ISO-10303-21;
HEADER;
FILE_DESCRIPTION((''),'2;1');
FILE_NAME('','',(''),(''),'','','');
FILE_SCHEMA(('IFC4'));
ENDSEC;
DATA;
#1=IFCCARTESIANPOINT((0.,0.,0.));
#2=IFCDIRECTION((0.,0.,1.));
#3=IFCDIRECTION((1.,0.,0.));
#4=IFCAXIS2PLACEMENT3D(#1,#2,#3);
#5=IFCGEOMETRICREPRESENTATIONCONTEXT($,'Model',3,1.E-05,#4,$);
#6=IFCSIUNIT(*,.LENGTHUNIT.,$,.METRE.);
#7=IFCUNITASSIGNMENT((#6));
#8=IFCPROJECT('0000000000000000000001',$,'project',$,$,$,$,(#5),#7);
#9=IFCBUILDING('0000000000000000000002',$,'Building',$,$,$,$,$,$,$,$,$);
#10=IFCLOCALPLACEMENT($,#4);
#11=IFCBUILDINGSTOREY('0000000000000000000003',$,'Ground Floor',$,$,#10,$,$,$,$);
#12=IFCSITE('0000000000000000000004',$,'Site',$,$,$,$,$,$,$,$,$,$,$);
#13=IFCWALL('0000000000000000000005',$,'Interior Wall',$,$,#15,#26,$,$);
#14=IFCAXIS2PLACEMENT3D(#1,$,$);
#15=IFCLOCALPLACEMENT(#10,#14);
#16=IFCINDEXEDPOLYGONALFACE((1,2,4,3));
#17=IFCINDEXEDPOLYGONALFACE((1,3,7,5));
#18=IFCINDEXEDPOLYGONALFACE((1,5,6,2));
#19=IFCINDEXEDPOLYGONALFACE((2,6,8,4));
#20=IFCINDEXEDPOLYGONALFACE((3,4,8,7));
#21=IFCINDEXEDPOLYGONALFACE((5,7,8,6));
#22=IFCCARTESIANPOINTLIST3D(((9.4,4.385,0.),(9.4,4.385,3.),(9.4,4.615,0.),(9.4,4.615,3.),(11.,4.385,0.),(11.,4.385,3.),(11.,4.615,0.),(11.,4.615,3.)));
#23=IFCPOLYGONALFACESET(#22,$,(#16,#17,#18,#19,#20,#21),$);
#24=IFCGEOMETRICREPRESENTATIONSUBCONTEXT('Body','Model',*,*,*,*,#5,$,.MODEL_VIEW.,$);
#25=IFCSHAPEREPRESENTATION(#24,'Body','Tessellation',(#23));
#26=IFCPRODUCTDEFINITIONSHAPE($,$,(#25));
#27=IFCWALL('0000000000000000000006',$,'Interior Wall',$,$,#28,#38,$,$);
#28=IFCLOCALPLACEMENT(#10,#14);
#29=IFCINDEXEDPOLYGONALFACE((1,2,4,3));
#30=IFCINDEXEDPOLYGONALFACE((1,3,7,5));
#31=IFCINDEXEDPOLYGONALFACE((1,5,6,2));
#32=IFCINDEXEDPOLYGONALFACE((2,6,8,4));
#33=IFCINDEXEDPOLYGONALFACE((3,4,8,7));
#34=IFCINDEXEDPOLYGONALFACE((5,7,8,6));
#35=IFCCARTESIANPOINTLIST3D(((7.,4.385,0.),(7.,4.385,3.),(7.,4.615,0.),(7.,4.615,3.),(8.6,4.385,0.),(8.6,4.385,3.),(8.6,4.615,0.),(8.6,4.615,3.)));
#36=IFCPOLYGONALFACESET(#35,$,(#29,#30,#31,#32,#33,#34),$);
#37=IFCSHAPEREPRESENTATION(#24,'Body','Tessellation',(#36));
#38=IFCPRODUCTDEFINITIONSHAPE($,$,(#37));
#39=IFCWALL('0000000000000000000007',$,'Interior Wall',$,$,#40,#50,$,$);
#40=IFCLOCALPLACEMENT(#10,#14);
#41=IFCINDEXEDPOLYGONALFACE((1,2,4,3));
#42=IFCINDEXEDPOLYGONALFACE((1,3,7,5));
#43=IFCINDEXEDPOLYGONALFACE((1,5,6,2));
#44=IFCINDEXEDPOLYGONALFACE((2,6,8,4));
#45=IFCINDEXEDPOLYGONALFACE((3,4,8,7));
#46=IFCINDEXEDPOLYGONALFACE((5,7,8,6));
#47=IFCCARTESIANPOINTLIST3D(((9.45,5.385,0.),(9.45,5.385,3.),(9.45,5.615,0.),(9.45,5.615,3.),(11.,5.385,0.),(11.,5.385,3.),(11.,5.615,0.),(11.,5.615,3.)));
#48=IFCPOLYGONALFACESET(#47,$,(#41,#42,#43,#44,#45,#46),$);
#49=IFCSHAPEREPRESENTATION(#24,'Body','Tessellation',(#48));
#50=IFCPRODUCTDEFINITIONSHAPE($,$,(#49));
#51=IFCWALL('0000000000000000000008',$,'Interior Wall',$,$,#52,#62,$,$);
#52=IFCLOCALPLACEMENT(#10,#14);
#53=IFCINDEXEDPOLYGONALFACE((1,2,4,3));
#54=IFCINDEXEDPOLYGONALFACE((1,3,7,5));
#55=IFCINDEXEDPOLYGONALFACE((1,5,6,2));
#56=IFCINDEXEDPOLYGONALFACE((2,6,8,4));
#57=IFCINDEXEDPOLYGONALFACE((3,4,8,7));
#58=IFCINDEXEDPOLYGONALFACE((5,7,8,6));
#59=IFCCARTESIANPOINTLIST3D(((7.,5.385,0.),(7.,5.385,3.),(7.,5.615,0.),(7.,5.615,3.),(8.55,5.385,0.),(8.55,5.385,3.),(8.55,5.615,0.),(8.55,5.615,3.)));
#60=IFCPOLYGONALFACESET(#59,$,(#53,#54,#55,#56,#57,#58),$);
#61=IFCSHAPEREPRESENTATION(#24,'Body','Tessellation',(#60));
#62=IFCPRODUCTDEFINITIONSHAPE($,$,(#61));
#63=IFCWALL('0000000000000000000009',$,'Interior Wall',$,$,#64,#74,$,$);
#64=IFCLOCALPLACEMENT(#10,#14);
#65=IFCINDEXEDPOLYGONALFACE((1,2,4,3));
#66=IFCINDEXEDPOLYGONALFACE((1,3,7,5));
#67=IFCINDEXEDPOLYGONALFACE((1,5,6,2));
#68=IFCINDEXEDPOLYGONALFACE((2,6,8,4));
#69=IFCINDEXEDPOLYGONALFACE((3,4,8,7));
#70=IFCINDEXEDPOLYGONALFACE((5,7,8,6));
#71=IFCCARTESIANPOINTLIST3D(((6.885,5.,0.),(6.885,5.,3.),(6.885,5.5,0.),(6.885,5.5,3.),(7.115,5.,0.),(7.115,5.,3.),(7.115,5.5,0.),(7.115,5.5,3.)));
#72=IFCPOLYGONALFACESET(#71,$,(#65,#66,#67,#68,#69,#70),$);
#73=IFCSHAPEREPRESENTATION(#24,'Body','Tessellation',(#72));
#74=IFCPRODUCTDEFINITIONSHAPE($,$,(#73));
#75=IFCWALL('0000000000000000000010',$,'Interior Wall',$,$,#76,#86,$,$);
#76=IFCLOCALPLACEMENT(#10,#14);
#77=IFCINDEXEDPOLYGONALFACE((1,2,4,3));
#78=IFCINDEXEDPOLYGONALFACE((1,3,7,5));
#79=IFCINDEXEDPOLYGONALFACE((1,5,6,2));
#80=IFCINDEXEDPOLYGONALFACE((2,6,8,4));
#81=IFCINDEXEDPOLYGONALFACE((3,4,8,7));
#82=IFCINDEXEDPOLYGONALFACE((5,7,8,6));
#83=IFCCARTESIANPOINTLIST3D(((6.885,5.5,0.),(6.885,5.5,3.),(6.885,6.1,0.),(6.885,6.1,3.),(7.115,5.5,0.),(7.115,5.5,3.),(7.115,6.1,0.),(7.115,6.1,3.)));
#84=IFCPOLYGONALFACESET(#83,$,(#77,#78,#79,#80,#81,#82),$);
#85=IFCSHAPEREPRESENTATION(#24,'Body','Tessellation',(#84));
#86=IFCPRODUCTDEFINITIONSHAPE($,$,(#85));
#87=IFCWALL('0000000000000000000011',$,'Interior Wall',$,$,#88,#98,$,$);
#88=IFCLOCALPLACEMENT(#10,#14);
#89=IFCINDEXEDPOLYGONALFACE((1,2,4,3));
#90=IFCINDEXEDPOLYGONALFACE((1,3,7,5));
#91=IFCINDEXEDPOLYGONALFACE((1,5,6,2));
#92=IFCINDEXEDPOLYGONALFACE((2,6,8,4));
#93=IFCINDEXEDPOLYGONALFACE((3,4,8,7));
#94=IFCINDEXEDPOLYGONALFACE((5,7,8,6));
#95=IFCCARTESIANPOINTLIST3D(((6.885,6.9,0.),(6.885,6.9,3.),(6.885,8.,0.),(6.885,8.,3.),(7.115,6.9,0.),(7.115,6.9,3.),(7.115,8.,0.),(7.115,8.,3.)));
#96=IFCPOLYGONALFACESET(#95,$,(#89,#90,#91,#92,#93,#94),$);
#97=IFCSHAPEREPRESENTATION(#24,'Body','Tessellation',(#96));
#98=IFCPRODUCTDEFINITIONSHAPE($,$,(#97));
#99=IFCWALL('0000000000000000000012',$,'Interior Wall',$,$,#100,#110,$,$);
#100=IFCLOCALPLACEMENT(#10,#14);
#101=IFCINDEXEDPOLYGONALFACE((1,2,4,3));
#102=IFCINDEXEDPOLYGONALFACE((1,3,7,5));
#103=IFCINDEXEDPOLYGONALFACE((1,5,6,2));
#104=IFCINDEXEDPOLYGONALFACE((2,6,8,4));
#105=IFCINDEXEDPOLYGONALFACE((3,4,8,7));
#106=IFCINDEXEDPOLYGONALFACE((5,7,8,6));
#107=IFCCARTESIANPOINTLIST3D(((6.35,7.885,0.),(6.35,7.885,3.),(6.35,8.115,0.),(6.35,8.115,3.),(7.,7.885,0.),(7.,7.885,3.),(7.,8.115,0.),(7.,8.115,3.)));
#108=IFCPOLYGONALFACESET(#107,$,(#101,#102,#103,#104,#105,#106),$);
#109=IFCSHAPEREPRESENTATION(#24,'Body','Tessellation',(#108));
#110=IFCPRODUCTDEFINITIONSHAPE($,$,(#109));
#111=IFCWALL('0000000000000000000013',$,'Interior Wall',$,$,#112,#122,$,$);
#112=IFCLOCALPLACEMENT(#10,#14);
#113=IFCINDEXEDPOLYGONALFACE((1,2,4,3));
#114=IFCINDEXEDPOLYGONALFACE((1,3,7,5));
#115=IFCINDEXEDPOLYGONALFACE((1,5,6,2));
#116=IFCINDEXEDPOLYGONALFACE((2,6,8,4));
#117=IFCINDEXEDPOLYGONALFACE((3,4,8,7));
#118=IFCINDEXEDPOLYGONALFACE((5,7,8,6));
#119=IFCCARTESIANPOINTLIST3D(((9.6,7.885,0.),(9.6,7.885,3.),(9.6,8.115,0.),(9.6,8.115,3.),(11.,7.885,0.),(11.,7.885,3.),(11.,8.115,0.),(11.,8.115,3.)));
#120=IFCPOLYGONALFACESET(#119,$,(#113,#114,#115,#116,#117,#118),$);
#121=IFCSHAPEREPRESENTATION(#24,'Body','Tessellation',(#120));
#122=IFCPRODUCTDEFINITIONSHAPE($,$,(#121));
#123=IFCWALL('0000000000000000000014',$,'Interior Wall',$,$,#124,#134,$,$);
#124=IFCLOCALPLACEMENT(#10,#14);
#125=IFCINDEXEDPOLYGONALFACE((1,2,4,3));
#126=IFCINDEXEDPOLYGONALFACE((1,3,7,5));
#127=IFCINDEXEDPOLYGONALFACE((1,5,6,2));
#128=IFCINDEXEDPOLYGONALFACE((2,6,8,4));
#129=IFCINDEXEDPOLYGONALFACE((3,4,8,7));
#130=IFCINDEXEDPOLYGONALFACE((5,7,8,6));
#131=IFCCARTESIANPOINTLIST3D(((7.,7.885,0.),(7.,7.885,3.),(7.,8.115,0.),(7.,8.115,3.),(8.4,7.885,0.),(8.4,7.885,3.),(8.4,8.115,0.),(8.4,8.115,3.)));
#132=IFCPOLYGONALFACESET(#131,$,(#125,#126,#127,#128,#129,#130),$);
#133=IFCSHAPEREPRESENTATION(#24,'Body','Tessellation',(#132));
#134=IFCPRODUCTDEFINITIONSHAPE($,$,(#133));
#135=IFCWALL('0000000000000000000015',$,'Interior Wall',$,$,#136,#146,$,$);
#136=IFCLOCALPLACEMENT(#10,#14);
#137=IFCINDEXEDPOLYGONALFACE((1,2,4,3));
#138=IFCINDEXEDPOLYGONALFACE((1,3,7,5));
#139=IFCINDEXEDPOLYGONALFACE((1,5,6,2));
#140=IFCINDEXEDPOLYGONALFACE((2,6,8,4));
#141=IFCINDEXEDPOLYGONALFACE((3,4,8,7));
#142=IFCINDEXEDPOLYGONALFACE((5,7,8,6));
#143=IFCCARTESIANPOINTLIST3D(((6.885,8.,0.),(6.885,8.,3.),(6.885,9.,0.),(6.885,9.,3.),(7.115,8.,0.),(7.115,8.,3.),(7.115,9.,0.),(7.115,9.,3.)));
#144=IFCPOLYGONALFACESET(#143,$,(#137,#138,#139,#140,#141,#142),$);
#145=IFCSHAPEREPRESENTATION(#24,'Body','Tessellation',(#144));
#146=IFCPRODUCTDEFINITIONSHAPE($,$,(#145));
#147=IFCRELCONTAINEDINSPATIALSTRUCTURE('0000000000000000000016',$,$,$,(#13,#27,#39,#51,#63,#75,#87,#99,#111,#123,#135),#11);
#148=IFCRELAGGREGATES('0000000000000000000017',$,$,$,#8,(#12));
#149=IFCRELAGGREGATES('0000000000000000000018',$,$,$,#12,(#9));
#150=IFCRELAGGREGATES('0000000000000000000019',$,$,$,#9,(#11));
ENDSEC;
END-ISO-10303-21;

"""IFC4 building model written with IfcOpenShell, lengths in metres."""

from ifc_helpers import new_model, si_unit, frame, origin_with_axes, place, context, subcontext, project, spatial, indexed_curve, outline, extrude, element, save


model = new_model("IFC4")

# Units and contexts
model_context = context("Model", 3, precision=1e-05, world=origin_with_axes())
body_context = subcontext(model_context, "Body", "Model", "MODEL_VIEW")
ifc_project = project(units=[si_unit("LENGTHUNIT", "METRE")], contexts=[model_context])

# Site, building, storey
site = spatial("IfcSite", under=ifc_project, Name="Site")
building = spatial("IfcBuilding", under=site, Name="Building")
storey_placement = place(None, origin_with_axes())
storey = spatial("IfcBuildingStorey", under=building, at=storey_placement, Name="Ground Floor")

# Walls
for number, where, z_axis, x_axis, name in (
    (1, (11.0, 4.5, 0.0), (0.0, 0.0, 1.0), (-1.0, 0.0, 0.0), "Interior Wall"),
    (2, (8.6, 4.5, 0.0), (0.0, 0.0, 1.0), (-1.0, 0.0, 0.0), "Interior Wall"),
):
    element("IfcWall", number, at=place(storey_placement, frame(where, z_axis=z_axis, x_axis=x_axis)), inside=storey, Name=name, context=body_context, shape_type="SweptSolid", body=[
        extrude(outline(indexed_curve([(0.0, 0.0), (0.0, 0.23), (1.6, 0.23), (1.6, 0.0), (0.0, 0.0)], self_intersect=False)), frame((0.0, -0.115, 0.0), z_axis=(0.0, 0.0, 1.0), x_axis=(1.0, 0.0, 0.0)), (0.0, 0.0, 1.0), 3.0),
    ])
for number, where, z_axis, x_axis, name in (
    (3, (11.0, 5.5, 0.0), (0.0, 0.0, 1.0), (-1.0, 0.0, 0.0), "Interior Wall"),
    (4, (8.55, 5.5, 0.0), (0.0, 0.0, 1.0), (-1.0, 0.0, 0.0), "Interior Wall"),
):
    element("IfcWall", number, at=place(storey_placement, frame(where, z_axis=z_axis, x_axis=x_axis)), inside=storey, Name=name, context=body_context, shape_type="SweptSolid", body=[
        extrude(outline(indexed_curve([(0.0, 0.0), (0.0, 0.23), (1.55, 0.23), (1.55, 0.0), (0.0, 0.0)], self_intersect=False)), frame((0.0, -0.115, 0.0), z_axis=(0.0, 0.0, 1.0), x_axis=(1.0, 0.0, 0.0)), (0.0, 0.0, 1.0), 3.0),
    ])
wall_1_placement = place(storey_placement, frame((7.0, 5.5, 0.0), z_axis=(0.0, 0.0, 1.0), x_axis=(0.0, -1.0, 0.0)))
element("IfcWall", 5, at=wall_1_placement, inside=storey, Name="Interior Wall", context=body_context, shape_type="SweptSolid", body=[
    extrude(outline(indexed_curve([(0.0, 0.0), (0.0, 0.23), (0.5, 0.23), (0.5, 0.0), (0.0, 0.0)], self_intersect=False)), frame((0.0, -0.115, 0.0), z_axis=(0.0, 0.0, 1.0), x_axis=(1.0, 0.0, 0.0)), (0.0, 0.0, 1.0), 3.0),
])
wall_2_placement = place(storey_placement, frame((7.0, 5.5, 0.0), z_axis=(0.0, 0.0, 1.0), x_axis=(0.0, 1.0, 0.0)))
element("IfcWall", 6, at=wall_2_placement, inside=storey, Name="Interior Wall", context=body_context, shape_type="SweptSolid", body=[
    extrude(outline(indexed_curve([(0.0, 0.0), (0.0, 0.23), (0.6, 0.23), (0.6, 0.0), (0.0, 0.0)], self_intersect=False)), frame((0.0, -0.115, 0.0), z_axis=(0.0, 0.0, 1.0), x_axis=(1.0, 0.0, 0.0)), (0.0, 0.0, 1.0), 3.0),
])
wall_3_placement = place(storey_placement, frame((7.0, 6.9, 0.0), z_axis=(0.0, 0.0, 1.0), x_axis=(0.0, 1.0, 0.0)))
element("IfcWall", 7, at=wall_3_placement, inside=storey, Name="Interior Wall", context=body_context, shape_type="SweptSolid", body=[
    extrude(outline(indexed_curve([(0.0, 0.0), (0.0, 0.23), (1.1, 0.23), (1.1, 0.0), (0.0, 0.0)], self_intersect=False)), frame((0.0, -0.115, 0.0), z_axis=(0.0, 0.0, 1.0), x_axis=(1.0, 0.0, 0.0)), (0.0, 0.0, 1.0), 3.0),
])
wall_4_placement = place(storey_placement, frame((7.0, 8.0, 0.0), z_axis=(0.0, 0.0, 1.0), x_axis=(-1.0, 0.0, 0.0)))
element("IfcWall", 8, at=wall_4_placement, inside=storey, Name="Interior Wall", context=body_context, shape_type="SweptSolid", body=[
    extrude(outline(indexed_curve([(0.0, 0.0), (0.0, 0.23), (0.65, 0.23), (0.65, 0.0), (0.0, 0.0)], self_intersect=False)), frame((0.0, -0.115, 0.0), z_axis=(0.0, 0.0, 1.0), x_axis=(1.0, 0.0, 0.0)), (0.0, 0.0, 1.0), 3.0),
])
for number, where, z_axis, x_axis, name in (
    (9, (11.0, 8.0, 0.0), (0.0, 0.0, 1.0), (-1.0, 0.0, 0.0), "Interior Wall"),
    (10, (8.4, 8.0, 0.0), (0.0, 0.0, 1.0), (-1.0, 0.0, 0.0), "Interior Wall"),
):
    element("IfcWall", number, at=place(storey_placement, frame(where, z_axis=z_axis, x_axis=x_axis)), inside=storey, Name=name, context=body_context, shape_type="SweptSolid", body=[
        extrude(outline(indexed_curve([(0.0, 0.0), (0.0, 0.23), (1.4, 0.23), (1.4, 0.0), (0.0, 0.0)], self_intersect=False)), frame((0.0, -0.115, 0.0), z_axis=(0.0, 0.0, 1.0), x_axis=(1.0, 0.0, 0.0)), (0.0, 0.0, 1.0), 3.0),
    ])
wall_5_placement = place(storey_placement, frame((7.0, 8.0, 0.0), z_axis=(0.0, 0.0, 1.0), x_axis=(0.0, 1.0, 0.0)))
element("IfcWall", 11, at=wall_5_placement, inside=storey, Name="Interior Wall", context=body_context, shape_type="SweptSolid", body=[
    extrude(outline(indexed_curve([(0.0, 0.0), (0.0, 0.23), (1.0, 0.23), (1.0, 0.0), (0.0, 0.0)], self_intersect=False)), frame((0.0, -0.115, 0.0), z_axis=(0.0, 0.0, 1.0), x_axis=(1.0, 0.0, 0.0)), (0.0, 0.0, 1.0), 3.0),
])

save(model, "model.ifc")
